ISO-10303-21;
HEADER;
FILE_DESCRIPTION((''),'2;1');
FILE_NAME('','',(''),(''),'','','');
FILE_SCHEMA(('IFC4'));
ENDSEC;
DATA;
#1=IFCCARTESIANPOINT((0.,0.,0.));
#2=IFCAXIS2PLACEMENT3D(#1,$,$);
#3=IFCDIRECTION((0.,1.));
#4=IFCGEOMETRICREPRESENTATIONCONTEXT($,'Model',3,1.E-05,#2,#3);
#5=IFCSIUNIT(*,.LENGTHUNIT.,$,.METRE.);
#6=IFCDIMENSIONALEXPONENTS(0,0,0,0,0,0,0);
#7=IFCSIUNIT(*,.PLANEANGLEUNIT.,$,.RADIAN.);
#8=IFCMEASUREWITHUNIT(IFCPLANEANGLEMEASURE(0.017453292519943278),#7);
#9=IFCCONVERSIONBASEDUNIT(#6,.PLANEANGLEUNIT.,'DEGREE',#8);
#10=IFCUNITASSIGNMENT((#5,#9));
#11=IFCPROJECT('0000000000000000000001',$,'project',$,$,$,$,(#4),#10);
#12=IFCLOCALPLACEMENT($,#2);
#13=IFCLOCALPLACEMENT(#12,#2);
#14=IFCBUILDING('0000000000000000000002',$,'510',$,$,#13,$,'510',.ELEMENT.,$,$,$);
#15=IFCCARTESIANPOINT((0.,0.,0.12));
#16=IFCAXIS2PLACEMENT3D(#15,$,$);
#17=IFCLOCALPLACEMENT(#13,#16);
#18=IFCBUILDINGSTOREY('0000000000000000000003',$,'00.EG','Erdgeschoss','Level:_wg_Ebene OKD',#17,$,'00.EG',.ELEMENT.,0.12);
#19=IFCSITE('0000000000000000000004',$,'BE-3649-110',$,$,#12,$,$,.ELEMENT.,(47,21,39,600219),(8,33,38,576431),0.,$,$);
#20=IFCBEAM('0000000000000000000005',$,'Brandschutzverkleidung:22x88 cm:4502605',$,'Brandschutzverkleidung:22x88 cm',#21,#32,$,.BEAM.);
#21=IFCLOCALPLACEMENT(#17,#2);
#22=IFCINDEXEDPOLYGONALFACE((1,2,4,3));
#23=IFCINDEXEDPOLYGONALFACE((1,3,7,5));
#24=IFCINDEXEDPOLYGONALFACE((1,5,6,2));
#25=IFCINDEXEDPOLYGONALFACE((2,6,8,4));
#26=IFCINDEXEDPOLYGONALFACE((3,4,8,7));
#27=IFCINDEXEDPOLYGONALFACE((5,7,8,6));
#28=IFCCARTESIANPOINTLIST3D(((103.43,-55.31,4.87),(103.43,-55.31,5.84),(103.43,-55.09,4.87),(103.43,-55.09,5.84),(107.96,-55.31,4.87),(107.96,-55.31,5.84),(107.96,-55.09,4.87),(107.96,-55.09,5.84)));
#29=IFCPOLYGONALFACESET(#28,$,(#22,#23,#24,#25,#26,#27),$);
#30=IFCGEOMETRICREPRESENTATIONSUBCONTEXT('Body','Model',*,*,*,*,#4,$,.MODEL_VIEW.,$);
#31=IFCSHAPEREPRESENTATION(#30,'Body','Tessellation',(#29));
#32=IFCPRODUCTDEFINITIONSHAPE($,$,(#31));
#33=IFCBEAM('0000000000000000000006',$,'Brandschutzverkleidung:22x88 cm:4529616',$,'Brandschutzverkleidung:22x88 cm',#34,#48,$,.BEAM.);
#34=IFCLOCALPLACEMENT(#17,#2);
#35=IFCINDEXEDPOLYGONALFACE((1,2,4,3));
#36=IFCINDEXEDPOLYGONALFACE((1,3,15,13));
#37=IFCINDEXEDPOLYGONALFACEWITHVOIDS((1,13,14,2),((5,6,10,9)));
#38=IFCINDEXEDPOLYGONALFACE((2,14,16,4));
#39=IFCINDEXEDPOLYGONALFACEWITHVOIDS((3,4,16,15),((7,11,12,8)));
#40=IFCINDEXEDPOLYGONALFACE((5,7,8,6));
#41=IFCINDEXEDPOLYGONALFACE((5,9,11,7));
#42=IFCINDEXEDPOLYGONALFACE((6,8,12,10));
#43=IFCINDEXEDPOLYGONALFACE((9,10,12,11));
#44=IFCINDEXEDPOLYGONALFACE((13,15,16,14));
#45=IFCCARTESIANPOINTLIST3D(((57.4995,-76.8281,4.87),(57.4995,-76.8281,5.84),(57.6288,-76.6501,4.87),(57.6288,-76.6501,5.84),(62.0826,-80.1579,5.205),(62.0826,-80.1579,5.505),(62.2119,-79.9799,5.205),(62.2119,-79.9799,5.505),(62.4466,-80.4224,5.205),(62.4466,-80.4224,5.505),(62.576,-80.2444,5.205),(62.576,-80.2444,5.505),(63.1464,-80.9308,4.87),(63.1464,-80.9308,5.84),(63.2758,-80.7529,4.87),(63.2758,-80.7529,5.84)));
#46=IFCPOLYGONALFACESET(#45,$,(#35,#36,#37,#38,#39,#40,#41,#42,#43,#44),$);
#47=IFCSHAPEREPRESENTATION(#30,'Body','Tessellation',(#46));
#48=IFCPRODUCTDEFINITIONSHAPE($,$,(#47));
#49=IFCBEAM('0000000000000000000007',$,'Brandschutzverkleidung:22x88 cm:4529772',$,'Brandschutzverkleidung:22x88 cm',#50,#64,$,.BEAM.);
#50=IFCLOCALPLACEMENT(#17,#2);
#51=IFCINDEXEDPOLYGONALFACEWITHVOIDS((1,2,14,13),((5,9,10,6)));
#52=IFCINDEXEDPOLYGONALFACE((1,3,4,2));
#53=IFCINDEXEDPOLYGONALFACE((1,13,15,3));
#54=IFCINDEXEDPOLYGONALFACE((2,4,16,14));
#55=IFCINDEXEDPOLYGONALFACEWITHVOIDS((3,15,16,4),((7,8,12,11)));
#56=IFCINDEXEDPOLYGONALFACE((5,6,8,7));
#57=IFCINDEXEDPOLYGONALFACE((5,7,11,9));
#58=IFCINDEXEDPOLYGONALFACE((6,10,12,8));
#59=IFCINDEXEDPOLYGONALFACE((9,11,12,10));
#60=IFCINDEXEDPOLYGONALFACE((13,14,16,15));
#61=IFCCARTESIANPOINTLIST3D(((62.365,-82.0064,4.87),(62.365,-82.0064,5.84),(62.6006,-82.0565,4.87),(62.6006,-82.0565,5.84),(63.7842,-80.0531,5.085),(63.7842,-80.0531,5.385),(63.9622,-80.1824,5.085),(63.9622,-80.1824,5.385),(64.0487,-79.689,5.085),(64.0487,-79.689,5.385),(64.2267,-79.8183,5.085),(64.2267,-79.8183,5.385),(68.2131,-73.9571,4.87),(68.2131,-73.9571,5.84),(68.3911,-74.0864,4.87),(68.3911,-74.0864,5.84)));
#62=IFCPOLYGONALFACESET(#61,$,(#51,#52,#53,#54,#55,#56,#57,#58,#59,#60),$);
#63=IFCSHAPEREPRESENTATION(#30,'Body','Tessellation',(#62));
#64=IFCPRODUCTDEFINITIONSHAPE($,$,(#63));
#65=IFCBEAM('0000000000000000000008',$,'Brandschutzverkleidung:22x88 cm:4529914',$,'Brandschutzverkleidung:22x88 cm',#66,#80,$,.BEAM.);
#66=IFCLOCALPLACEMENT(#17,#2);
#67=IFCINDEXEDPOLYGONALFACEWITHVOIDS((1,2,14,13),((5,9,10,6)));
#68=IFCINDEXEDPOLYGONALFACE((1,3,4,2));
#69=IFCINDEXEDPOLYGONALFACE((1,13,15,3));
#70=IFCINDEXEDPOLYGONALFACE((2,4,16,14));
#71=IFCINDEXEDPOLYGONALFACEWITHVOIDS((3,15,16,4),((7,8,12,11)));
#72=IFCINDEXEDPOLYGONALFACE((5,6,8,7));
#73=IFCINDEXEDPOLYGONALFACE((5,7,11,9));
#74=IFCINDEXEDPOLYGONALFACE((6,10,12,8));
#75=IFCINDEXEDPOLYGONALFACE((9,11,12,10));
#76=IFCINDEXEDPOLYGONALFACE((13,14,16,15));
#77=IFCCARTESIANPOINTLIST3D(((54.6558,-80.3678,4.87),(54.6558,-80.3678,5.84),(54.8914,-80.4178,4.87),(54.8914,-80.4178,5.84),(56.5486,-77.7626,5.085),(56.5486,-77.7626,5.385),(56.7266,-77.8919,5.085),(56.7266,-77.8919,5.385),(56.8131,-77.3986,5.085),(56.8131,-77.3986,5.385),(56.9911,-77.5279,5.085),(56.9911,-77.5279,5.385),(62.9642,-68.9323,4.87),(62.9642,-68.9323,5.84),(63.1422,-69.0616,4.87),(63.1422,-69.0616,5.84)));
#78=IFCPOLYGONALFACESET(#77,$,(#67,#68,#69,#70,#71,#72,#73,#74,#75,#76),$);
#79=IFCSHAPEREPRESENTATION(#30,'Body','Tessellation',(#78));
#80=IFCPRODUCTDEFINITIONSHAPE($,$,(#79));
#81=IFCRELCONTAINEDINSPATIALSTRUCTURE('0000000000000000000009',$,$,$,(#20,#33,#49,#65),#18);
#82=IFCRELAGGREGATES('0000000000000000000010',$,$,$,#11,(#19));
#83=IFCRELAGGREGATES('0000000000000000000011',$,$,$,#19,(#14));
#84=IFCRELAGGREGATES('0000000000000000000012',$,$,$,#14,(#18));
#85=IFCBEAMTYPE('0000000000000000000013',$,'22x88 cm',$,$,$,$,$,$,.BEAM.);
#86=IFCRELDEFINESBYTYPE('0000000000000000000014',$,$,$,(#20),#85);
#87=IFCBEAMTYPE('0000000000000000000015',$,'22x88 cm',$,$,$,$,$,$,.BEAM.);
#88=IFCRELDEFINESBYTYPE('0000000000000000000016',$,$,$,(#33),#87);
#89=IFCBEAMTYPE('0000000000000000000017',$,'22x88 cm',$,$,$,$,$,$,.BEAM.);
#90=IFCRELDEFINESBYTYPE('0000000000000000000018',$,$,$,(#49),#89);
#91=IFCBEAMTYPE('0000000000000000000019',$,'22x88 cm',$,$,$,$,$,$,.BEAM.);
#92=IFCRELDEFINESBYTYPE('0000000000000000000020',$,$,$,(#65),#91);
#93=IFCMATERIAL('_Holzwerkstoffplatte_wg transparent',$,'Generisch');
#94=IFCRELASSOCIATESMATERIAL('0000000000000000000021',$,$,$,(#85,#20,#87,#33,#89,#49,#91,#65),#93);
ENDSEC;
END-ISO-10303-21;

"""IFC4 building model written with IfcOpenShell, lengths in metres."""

from ifc_helpers import new_model, entity, si_unit, converted_unit, direction, frame, origin, place, context, subcontext, project, spatial, indexed_curve, outline, extrude, source, transform, mapped, material, type_object, type_shapes, element, save


model = new_model("IFC4")

# Units and contexts
model_context = context("Model", 3, precision=1e-05, world=origin(), true_north=direction((0.0, 1.0)))
body_context = subcontext(model_context, "Body", "Model", "MODEL_VIEW")
ifc_project = project(units=[si_unit("LENGTHUNIT", "METRE"), converted_unit("PLANEANGLEUNIT", "DEGREE", entity("IfcPlaneAngleMeasure", 0.017453292519943278), si_unit("PLANEANGLEUNIT", "RADIAN"), dimensions=[0, 0, 0, 0, 0, 0, 0])], contexts=[model_context])

# Site, building, storey
site_placement = place(None, origin())
site = spatial("IfcSite", under=ifc_project, at=site_placement, Name="BE-3649-110", CompositionType="ELEMENT", RefLatitude=(47, 21, 39, 600219), RefLongitude=(8, 33, 38, 576431), RefElevation=0.0)
building_placement = place(site_placement, origin())
building = spatial("IfcBuilding", under=site, at=building_placement, Name="510", LongName="510", CompositionType="ELEMENT")
storey_placement = place(building_placement, frame((0.0, 0.0, 0.12)))
storey = spatial("IfcBuildingStorey", under=building, at=storey_placement, Name="00.EG", Description="Erdgeschoss", ObjectType="Level:_wg_Ebene OKD", LongName="00.EG", CompositionType="ELEMENT", Elevation=0.12)

# Beams
ifc_material = material(Name="_Holzwerkstoffplatte_wg transparent", Category="Generisch")
beam_type_1 = type_object("IfcBeamType", Name="22x88 cm", PredefinedType="BEAM", material=ifc_material)
shared_shape_1 = source(origin(), body_context, "Body", "SweptSolid", [
    extrude(outline(indexed_curve([(-2.265, -0.11), (2.265, -0.11), (2.265, 0.11), (-2.265, 0.11), (-2.265, -0.11)], self_intersect=False)), frame((105.695, -55.2, -0.485), z_axis=(0.0, 0.0, 1.0), x_axis=(-1.0, 0.0, 0.0)), (0.0, 0.0, 1.0), 0.97),
])
type_shapes(beam_type_1, [shared_shape_1])
beam_1_placement = place(storey_placement, frame((0.0, 0.0, 5.355)))
element("IfcBeam", 1, at=beam_1_placement, inside=storey, type_object=beam_type_1, material=ifc_material, Name="Brandschutzverkleidung:22x88 cm:4502605", ObjectType="Brandschutzverkleidung:22x88 cm", PredefinedType="BEAM", context=body_context, shape_type="MappedRepresentation", body=[
    mapped(shared_shape_1, transform((0.0, 0.0, 0.0), scale=1.0)),
])
beam_type_2 = type_object("IfcBeamType", Name="22x88 cm", PredefinedType="BEAM", material=ifc_material)
shared_shape_2 = source(origin(), body_context, "Body", "SweptSolid", [
    extrude(outline(indexed_curve([(-3.49, -0.485), (3.49, -0.485), (3.49, 0.485), (-3.49, 0.485), (-3.49, -0.485)], self_intersect=False), holes=[indexed_curve([(2.175, -0.15), (2.175, 0.15), (2.625, 0.15), (2.625, -0.15), (2.175, -0.15)], self_intersect=False)]), frame((60.323, -78.8795, 0.0), z_axis=(0.587785, 0.809017, 0.0), x_axis=(0.809017, -0.587785, 0.0)), (0.0, 0.0, 1.0), 0.22),
])
type_shapes(beam_type_2, [shared_shape_2])
beam_2_placement = place(storey_placement, frame((0.0, 0.0, 5.355)))
element("IfcBeam", 2, at=beam_2_placement, inside=storey, type_object=beam_type_2, material=ifc_material, Name="Brandschutzverkleidung:22x88 cm:4529616", ObjectType="Brandschutzverkleidung:22x88 cm", PredefinedType="BEAM", context=body_context, shape_type="MappedRepresentation", body=[
    mapped(shared_shape_2, transform((0.0, 0.0, 0.0), scale=1.0)),
])

# Beams, openings
beam_type_3 = type_object("IfcBeamType", Name="22x88 cm", PredefinedType="BEAM", material=ifc_material)
shared_shape_3 = source(origin(), body_context, "Body", "SweptSolid", [
    extrude(outline(indexed_curve([(-4.9502, -0.11), (4.9992, -0.11), (4.9013, 0.11), (-4.9502, 0.11), (-4.9502, -0.11)], self_intersect=False)), frame((65.3925, -78.0266, -0.485), z_axis=(0.0, 0.0, 1.0), x_axis=(-0.587785, -0.809017, 0.0)), (0.0, 0.0, 1.0), 0.97),
])
type_shapes(beam_type_3, [shared_shape_3])
beam_3_placement = place(storey_placement, frame((0.0, 0.0, 5.355)))
beam_3 = element("IfcBeam", 3, at=beam_3_placement, inside=storey, type_object=beam_type_3, material=ifc_material, Name="Brandschutzverkleidung:22x88 cm:4529772", ObjectType="Brandschutzverkleidung:22x88 cm", PredefinedType="BEAM", context=body_context, shape_type="MappedRepresentation", body=[
    mapped(shared_shape_3, transform((0.0, 0.0, 0.0), scale=1.0)),
])
opening_1_placement = place(storey_placement, frame((0.0, 0.0, 5.355)))
element("IfcOpeningElement", 4, at=opening_1_placement, cuts=beam_3, PredefinedType="OPENING", context=body_context, shape_type="SweptSolid", body=[
    extrude(outline(indexed_curve([(-0.225, -0.15), (0.225, -0.15), (0.225, 0.15), (-0.225, 0.15), (-0.225, -0.15)], self_intersect=False)), frame((63.9164, -79.871, -0.12), z_axis=(0.809017, -0.587785, 0.0), x_axis=(0.587785, 0.809017, 0.0)), (0.0, 0.0, 1.0), 0.22),
])
beam_type_4 = type_object("IfcBeamType", Name="22x88 cm", PredefinedType="BEAM", material=ifc_material)
shared_shape_4 = source(origin(), body_context, "Body", "SweptSolid", [
    extrude(outline(indexed_curve([(-7.043, -0.11), (7.092, -0.11), (6.9941, 0.11), (-7.043, 0.11), (-7.043, -0.11)], self_intersect=False)), frame((58.9134, -74.6949, -0.485), z_axis=(0.0, 0.0, 1.0), x_axis=(-0.587785, -0.809017, 0.0)), (0.0, 0.0, 1.0), 0.97),
])
type_shapes(beam_type_4, [shared_shape_4])
beam_4_placement = place(storey_placement, frame((0.0, 0.0, 5.355)))
beam_4 = element("IfcBeam", 5, at=beam_4_placement, inside=storey, type_object=beam_type_4, material=ifc_material, Name="Brandschutzverkleidung:22x88 cm:4529914", ObjectType="Brandschutzverkleidung:22x88 cm", PredefinedType="BEAM", context=body_context, shape_type="MappedRepresentation", body=[
    mapped(shared_shape_4, transform((0.0, 0.0, 0.0), scale=1.0)),
])
opening_2_placement = place(storey_placement, frame((0.0, 0.0, 5.355)))
element("IfcOpeningElement", 6, at=opening_2_placement, cuts=beam_4, PredefinedType="OPENING", context=body_context, shape_type="SweptSolid", body=[
    extrude(outline(indexed_curve([(-0.225, -0.15), (0.225, -0.15), (0.225, 0.15), (-0.225, 0.15), (-0.225, -0.15)], self_intersect=False)), frame((56.8588, -77.7099, -0.12), z_axis=(-0.809017, 0.587785, 0.0), x_axis=(-0.587785, -0.809017, 0.0)), (0.0, 0.0, 1.0), 0.22),
])

save(model, "model.ifc")
